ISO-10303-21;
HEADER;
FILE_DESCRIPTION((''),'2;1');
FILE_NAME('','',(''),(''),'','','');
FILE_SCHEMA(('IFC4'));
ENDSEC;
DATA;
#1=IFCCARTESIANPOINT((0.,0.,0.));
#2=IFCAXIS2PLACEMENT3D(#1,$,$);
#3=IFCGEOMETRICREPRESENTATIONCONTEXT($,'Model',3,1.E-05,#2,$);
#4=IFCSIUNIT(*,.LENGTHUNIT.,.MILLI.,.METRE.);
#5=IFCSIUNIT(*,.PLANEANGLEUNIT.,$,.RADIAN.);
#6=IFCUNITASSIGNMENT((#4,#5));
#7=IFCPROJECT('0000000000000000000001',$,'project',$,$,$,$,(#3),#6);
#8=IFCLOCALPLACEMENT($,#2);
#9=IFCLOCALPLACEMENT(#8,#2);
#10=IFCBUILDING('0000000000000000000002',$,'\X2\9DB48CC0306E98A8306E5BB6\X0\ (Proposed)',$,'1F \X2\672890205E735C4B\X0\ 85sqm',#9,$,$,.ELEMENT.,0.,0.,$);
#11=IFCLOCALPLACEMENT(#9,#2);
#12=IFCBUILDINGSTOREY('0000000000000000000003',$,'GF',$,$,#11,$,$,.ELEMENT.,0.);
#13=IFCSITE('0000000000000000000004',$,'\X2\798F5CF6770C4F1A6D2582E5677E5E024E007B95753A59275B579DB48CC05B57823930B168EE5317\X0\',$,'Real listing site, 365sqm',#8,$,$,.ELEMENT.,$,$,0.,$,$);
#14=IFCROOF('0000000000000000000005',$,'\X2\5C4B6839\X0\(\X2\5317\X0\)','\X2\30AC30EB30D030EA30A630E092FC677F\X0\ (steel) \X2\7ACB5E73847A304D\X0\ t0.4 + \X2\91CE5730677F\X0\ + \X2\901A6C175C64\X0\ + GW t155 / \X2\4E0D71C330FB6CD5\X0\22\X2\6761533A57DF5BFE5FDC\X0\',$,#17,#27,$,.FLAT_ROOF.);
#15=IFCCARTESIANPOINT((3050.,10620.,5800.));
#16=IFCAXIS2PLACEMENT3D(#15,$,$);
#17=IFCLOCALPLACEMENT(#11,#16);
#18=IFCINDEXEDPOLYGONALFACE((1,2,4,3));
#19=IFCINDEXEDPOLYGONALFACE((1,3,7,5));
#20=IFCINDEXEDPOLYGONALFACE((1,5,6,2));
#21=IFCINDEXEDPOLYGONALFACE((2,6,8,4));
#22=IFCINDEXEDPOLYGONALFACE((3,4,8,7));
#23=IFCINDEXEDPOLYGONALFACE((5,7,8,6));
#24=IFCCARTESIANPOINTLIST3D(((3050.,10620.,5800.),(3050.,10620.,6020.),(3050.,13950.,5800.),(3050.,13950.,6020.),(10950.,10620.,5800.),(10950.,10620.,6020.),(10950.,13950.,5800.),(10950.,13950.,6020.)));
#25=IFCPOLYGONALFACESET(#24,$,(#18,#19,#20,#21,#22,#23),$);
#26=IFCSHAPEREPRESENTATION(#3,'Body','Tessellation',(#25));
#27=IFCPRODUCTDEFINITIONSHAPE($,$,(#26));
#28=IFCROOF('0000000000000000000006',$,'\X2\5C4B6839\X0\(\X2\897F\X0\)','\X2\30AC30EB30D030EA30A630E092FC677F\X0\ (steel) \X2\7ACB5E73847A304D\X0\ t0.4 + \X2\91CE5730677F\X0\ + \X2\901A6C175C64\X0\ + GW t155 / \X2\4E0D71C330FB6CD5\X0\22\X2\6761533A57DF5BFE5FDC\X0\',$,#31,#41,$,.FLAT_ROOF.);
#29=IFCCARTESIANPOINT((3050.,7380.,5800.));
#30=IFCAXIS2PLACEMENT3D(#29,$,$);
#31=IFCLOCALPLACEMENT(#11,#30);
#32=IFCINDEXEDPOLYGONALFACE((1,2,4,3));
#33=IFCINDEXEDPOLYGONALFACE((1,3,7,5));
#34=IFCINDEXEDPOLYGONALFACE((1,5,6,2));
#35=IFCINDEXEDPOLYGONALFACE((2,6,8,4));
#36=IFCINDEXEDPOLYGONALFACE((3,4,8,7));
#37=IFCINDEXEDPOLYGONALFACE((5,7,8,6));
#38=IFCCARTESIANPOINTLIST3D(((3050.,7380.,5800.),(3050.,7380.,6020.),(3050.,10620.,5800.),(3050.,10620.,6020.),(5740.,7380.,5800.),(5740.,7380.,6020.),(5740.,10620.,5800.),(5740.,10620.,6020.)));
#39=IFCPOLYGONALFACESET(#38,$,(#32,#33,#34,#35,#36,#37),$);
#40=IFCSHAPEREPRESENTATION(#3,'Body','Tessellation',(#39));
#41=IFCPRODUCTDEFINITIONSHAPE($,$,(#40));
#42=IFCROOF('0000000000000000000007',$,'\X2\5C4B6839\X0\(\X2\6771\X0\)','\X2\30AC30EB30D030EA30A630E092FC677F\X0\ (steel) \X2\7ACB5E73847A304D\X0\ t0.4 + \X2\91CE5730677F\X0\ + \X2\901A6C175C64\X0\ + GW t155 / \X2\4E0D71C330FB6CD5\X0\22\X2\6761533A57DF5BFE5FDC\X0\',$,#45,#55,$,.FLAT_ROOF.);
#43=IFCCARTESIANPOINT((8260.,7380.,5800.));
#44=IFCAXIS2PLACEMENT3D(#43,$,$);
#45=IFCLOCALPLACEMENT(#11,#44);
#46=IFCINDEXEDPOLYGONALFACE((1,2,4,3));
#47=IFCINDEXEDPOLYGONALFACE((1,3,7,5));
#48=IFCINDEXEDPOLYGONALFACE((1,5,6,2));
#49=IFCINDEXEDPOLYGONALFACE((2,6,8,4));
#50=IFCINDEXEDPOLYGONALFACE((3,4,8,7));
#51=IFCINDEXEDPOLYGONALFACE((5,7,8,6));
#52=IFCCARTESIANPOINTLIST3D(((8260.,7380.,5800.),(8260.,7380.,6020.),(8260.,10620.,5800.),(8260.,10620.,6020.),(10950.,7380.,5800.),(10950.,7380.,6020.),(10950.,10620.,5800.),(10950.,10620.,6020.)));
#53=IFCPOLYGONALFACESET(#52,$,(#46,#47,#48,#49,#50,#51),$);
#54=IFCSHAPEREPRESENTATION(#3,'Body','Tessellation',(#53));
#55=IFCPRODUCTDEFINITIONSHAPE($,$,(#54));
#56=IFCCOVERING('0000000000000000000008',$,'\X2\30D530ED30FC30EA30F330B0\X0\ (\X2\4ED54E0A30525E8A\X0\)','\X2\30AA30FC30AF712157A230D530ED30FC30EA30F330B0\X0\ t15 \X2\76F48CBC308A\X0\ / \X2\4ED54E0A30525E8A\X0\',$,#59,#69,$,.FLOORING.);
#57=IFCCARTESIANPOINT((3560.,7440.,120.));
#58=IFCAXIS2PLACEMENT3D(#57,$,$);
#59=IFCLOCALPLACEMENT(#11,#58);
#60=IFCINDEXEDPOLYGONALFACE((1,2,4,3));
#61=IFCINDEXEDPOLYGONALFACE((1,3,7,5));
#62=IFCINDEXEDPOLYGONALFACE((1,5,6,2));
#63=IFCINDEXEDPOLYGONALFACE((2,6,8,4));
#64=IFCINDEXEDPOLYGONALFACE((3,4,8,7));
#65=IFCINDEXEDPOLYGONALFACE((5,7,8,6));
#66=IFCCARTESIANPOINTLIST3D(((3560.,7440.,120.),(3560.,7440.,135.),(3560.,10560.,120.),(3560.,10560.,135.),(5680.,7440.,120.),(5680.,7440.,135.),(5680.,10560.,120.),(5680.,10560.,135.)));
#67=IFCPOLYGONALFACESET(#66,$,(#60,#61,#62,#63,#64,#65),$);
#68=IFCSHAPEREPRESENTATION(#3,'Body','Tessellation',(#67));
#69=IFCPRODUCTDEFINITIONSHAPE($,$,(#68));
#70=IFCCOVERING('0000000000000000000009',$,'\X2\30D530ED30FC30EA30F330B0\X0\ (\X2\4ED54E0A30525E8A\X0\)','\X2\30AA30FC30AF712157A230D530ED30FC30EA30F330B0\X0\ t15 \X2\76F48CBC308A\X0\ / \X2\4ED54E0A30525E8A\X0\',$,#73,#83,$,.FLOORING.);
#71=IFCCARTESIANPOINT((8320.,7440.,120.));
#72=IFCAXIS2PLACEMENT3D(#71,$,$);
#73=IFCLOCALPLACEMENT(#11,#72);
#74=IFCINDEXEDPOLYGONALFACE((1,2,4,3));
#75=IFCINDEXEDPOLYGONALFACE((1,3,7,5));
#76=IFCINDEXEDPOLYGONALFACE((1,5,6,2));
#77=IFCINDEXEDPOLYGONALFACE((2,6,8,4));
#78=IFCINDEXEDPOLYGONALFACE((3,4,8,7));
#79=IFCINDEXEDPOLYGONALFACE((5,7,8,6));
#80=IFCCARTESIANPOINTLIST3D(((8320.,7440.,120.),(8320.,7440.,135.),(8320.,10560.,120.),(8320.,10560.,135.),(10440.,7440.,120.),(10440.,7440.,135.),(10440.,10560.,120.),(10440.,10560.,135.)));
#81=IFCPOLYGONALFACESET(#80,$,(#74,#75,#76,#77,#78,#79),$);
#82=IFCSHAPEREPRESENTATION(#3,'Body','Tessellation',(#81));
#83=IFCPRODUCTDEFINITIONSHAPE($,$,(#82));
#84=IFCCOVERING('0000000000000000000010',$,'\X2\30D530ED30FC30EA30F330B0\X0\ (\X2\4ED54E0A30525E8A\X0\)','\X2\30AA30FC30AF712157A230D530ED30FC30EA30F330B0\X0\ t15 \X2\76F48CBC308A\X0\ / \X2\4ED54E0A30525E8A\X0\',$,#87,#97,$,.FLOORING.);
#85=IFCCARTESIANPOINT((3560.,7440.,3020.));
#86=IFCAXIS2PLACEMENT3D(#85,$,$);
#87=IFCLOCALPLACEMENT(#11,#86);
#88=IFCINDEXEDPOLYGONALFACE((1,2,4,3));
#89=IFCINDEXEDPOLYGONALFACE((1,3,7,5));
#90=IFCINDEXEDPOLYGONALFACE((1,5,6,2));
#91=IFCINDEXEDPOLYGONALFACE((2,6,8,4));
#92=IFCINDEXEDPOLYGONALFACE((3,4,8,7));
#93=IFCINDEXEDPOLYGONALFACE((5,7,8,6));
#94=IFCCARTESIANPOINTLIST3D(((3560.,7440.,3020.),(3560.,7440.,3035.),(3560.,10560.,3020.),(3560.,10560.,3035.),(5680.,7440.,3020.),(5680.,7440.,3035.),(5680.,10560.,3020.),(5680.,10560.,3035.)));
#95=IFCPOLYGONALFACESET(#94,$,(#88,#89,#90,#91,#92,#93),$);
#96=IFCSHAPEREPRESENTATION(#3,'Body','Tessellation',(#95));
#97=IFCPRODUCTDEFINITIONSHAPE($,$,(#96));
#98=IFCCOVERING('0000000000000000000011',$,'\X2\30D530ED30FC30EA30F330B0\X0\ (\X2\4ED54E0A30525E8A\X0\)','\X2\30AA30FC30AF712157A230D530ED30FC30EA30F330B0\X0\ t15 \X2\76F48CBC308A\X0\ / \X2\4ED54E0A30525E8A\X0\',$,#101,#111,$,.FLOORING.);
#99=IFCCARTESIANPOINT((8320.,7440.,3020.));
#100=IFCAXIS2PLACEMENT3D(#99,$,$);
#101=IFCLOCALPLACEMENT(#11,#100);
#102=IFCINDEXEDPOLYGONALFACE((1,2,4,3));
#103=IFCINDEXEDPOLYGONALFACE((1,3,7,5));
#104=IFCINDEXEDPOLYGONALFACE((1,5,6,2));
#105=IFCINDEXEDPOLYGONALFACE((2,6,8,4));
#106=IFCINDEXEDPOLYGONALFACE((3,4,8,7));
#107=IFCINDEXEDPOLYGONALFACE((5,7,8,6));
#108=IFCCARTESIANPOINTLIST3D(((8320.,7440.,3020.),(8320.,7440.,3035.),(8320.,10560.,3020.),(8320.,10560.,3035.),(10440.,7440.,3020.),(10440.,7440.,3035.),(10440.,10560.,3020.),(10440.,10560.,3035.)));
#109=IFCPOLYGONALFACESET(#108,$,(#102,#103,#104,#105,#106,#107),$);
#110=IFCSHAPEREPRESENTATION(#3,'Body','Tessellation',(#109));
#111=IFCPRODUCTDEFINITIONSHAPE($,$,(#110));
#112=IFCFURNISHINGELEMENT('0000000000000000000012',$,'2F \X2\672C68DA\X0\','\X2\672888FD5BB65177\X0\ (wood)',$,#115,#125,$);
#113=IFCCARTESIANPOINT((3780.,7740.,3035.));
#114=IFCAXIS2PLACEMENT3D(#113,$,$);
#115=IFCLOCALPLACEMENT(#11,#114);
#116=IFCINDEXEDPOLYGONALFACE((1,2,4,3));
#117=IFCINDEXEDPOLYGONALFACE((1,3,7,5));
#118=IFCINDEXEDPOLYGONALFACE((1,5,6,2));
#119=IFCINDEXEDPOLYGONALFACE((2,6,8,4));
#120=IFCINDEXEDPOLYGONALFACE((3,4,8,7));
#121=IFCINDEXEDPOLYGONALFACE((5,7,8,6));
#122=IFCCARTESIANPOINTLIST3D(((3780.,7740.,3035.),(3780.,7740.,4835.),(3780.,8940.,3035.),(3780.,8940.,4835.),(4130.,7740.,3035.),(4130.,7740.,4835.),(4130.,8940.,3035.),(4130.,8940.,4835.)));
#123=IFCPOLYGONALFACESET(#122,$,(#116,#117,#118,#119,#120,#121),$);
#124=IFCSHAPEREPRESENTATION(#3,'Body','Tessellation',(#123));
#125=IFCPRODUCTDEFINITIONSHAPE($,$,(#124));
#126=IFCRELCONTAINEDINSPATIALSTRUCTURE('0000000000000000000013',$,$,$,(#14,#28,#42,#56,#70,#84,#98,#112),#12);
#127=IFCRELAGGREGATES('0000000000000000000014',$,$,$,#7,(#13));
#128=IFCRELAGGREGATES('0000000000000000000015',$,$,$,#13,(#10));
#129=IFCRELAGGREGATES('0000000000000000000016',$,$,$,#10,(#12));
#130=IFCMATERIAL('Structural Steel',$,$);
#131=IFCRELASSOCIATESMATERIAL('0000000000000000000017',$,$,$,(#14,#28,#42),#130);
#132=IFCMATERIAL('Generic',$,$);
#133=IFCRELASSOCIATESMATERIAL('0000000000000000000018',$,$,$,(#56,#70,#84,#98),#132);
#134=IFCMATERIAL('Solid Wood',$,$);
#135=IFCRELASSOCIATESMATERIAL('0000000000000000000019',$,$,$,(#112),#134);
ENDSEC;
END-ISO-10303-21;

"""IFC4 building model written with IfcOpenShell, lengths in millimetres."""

from ifc_helpers import new_model, si_unit, frame, frame_2d, origin, place, context, project, spatial, rectangle, extrude, material, element, save


model = new_model("IFC4")

# Units and contexts
model_context = context("Model", 3, precision=1e-05, world=origin())
ifc_project = project(units=[si_unit("LENGTHUNIT", "METRE", prefix="MILLI"), si_unit("PLANEANGLEUNIT", "RADIAN")], contexts=[model_context])

# Site, building, storey
site_placement = place(None, origin())
site = spatial("IfcSite", under=ifc_project, at=site_placement, Name="福島県会津若松市一箕町大字鶴賀字船ケ森北", ObjectType="Real listing site, 365sqm", CompositionType="ELEMENT", RefElevation=0.0)
building_placement = place(site_placement, origin())
building = spatial("IfcBuilding", under=site, at=building_placement, Name="鶴賀の風の家 (Proposed)", ObjectType="1F 木造平屋 85sqm", CompositionType="ELEMENT", ElevationOfRefHeight=0.0, ElevationOfTerrain=0.0)
storey_placement = place(building_placement, origin())
storey = spatial("IfcBuildingStorey", under=building, at=storey_placement, Name="GF", CompositionType="ELEMENT", Elevation=0.0)

# Shared definitions
ifc_material_1 = material(Name="Solid Wood")

# Shared definitions
ifc_material_2 = material(Name="Generic")

# Roofs
ifc_material_3 = material(Name="Structural Steel")
roof_1_placement = place(storey_placement, frame((3050.0, 10620.0, 5800.0)))
element("IfcRoof", 1, at=roof_1_placement, inside=storey, material=ifc_material_3, Name="屋根(北)", Description="ガルバリウム鋼板 (steel) 立平葺き t0.4 + 野地板 + 通気層 + GW t155 / 不燃・法22条区域対応", PredefinedType="FLAT_ROOF", context=model_context, shape_type="SweptSolid", body=[
    extrude(rectangle(XDim=7900.0, YDim=3330.0, at=frame_2d((3950.0, 1665.0))), frame((3050.0, 10620.0, 5800.0)), (0.0, 0.0, 1.0), 220.0),
])
roof_2_placement = place(storey_placement, frame((3050.0, 7380.0, 5800.0)))
element("IfcRoof", 2, at=roof_2_placement, inside=storey, material=ifc_material_3, Name="屋根(西)", Description="ガルバリウム鋼板 (steel) 立平葺き t0.4 + 野地板 + 通気層 + GW t155 / 不燃・法22条区域対応", PredefinedType="FLAT_ROOF", context=model_context, shape_type="SweptSolid", body=[
    extrude(rectangle(XDim=2690.0, YDim=3240.0, at=frame_2d((1345.0, 1620.0))), frame((3050.0, 7380.0, 5800.0)), (0.0, 0.0, 1.0), 220.0),
])
roof_3_placement = place(storey_placement, frame((8260.0, 7380.0, 5800.0)))
element("IfcRoof", 3, at=roof_3_placement, inside=storey, material=ifc_material_3, Name="屋根(東)", Description="ガルバリウム鋼板 (steel) 立平葺き t0.4 + 野地板 + 通気層 + GW t155 / 不燃・法22条区域対応", PredefinedType="FLAT_ROOF", context=model_context, shape_type="SweptSolid", body=[
    extrude(rectangle(XDim=2690.0, YDim=3240.0, at=frame_2d((1345.0, 1620.0))), frame((8260.0, 7380.0, 5800.0)), (0.0, 0.0, 1.0), 220.0),
])

# Coverings
covering_1_placement = place(storey_placement, frame((3560.0, 7440.0, 120.0)))
element("IfcCovering", 4, at=covering_1_placement, inside=storey, material=ifc_material_2, Name="フローリング (仕上げ床)", Description="オーク無垢フローリング t15 直貼り / 仕上げ床", PredefinedType="FLOORING", context=model_context, shape_type="SweptSolid", body=[
    extrude(rectangle(XDim=2120.0, YDim=3120.0, at=frame_2d((1060.0, 1560.0))), frame((3560.0, 7440.0, 120.0)), (0.0, 0.0, 1.0), 15.0),
])
covering_2_placement = place(storey_placement, frame((8320.0, 7440.0, 120.0)))
element("IfcCovering", 5, at=covering_2_placement, inside=storey, material=ifc_material_2, Name="フローリング (仕上げ床)", Description="オーク無垢フローリング t15 直貼り / 仕上げ床", PredefinedType="FLOORING", context=model_context, shape_type="SweptSolid", body=[
    extrude(rectangle(XDim=2120.0, YDim=3120.0, at=frame_2d((1060.0, 1560.0))), frame((8320.0, 7440.0, 120.0)), (0.0, 0.0, 1.0), 15.0),
])
covering_3_placement = place(storey_placement, frame((3560.0, 7440.0, 3020.0)))
element("IfcCovering", 6, at=covering_3_placement, inside=storey, material=ifc_material_2, Name="フローリング (仕上げ床)", Description="オーク無垢フローリング t15 直貼り / 仕上げ床", PredefinedType="FLOORING", context=model_context, shape_type="SweptSolid", body=[
    extrude(rectangle(XDim=2120.0, YDim=3120.0, at=frame_2d((1060.0, 1560.0))), frame((3560.0, 7440.0, 3020.0)), (0.0, 0.0, 1.0), 15.0),
])
covering_4_placement = place(storey_placement, frame((8320.0, 7440.0, 3020.0)))
element("IfcCovering", 7, at=covering_4_placement, inside=storey, material=ifc_material_2, Name="フローリング (仕上げ床)", Description="オーク無垢フローリング t15 直貼り / 仕上げ床", PredefinedType="FLOORING", context=model_context, shape_type="SweptSolid", body=[
    extrude(rectangle(XDim=2120.0, YDim=3120.0, at=frame_2d((1060.0, 1560.0))), frame((8320.0, 7440.0, 3020.0)), (0.0, 0.0, 1.0), 15.0),
])

# Furnishing element
furnishing_placement = place(storey_placement, frame((3780.0, 7740.0, 3035.0)))
element("IfcFurnishingElement", 8, at=furnishing_placement, inside=storey, material=ifc_material_1, Name="2F 本棚", Description="木製家具 (wood)", context=model_context, shape_type="SweptSolid", body=[
    extrude(rectangle(XDim=350.0, YDim=1200.0, at=frame_2d((175.0, 600.0))), frame((3780.0, 7740.0, 3035.0)), (0.0, 0.0, 1.0), 1800.0),
])

save(model, "model.ifc")
